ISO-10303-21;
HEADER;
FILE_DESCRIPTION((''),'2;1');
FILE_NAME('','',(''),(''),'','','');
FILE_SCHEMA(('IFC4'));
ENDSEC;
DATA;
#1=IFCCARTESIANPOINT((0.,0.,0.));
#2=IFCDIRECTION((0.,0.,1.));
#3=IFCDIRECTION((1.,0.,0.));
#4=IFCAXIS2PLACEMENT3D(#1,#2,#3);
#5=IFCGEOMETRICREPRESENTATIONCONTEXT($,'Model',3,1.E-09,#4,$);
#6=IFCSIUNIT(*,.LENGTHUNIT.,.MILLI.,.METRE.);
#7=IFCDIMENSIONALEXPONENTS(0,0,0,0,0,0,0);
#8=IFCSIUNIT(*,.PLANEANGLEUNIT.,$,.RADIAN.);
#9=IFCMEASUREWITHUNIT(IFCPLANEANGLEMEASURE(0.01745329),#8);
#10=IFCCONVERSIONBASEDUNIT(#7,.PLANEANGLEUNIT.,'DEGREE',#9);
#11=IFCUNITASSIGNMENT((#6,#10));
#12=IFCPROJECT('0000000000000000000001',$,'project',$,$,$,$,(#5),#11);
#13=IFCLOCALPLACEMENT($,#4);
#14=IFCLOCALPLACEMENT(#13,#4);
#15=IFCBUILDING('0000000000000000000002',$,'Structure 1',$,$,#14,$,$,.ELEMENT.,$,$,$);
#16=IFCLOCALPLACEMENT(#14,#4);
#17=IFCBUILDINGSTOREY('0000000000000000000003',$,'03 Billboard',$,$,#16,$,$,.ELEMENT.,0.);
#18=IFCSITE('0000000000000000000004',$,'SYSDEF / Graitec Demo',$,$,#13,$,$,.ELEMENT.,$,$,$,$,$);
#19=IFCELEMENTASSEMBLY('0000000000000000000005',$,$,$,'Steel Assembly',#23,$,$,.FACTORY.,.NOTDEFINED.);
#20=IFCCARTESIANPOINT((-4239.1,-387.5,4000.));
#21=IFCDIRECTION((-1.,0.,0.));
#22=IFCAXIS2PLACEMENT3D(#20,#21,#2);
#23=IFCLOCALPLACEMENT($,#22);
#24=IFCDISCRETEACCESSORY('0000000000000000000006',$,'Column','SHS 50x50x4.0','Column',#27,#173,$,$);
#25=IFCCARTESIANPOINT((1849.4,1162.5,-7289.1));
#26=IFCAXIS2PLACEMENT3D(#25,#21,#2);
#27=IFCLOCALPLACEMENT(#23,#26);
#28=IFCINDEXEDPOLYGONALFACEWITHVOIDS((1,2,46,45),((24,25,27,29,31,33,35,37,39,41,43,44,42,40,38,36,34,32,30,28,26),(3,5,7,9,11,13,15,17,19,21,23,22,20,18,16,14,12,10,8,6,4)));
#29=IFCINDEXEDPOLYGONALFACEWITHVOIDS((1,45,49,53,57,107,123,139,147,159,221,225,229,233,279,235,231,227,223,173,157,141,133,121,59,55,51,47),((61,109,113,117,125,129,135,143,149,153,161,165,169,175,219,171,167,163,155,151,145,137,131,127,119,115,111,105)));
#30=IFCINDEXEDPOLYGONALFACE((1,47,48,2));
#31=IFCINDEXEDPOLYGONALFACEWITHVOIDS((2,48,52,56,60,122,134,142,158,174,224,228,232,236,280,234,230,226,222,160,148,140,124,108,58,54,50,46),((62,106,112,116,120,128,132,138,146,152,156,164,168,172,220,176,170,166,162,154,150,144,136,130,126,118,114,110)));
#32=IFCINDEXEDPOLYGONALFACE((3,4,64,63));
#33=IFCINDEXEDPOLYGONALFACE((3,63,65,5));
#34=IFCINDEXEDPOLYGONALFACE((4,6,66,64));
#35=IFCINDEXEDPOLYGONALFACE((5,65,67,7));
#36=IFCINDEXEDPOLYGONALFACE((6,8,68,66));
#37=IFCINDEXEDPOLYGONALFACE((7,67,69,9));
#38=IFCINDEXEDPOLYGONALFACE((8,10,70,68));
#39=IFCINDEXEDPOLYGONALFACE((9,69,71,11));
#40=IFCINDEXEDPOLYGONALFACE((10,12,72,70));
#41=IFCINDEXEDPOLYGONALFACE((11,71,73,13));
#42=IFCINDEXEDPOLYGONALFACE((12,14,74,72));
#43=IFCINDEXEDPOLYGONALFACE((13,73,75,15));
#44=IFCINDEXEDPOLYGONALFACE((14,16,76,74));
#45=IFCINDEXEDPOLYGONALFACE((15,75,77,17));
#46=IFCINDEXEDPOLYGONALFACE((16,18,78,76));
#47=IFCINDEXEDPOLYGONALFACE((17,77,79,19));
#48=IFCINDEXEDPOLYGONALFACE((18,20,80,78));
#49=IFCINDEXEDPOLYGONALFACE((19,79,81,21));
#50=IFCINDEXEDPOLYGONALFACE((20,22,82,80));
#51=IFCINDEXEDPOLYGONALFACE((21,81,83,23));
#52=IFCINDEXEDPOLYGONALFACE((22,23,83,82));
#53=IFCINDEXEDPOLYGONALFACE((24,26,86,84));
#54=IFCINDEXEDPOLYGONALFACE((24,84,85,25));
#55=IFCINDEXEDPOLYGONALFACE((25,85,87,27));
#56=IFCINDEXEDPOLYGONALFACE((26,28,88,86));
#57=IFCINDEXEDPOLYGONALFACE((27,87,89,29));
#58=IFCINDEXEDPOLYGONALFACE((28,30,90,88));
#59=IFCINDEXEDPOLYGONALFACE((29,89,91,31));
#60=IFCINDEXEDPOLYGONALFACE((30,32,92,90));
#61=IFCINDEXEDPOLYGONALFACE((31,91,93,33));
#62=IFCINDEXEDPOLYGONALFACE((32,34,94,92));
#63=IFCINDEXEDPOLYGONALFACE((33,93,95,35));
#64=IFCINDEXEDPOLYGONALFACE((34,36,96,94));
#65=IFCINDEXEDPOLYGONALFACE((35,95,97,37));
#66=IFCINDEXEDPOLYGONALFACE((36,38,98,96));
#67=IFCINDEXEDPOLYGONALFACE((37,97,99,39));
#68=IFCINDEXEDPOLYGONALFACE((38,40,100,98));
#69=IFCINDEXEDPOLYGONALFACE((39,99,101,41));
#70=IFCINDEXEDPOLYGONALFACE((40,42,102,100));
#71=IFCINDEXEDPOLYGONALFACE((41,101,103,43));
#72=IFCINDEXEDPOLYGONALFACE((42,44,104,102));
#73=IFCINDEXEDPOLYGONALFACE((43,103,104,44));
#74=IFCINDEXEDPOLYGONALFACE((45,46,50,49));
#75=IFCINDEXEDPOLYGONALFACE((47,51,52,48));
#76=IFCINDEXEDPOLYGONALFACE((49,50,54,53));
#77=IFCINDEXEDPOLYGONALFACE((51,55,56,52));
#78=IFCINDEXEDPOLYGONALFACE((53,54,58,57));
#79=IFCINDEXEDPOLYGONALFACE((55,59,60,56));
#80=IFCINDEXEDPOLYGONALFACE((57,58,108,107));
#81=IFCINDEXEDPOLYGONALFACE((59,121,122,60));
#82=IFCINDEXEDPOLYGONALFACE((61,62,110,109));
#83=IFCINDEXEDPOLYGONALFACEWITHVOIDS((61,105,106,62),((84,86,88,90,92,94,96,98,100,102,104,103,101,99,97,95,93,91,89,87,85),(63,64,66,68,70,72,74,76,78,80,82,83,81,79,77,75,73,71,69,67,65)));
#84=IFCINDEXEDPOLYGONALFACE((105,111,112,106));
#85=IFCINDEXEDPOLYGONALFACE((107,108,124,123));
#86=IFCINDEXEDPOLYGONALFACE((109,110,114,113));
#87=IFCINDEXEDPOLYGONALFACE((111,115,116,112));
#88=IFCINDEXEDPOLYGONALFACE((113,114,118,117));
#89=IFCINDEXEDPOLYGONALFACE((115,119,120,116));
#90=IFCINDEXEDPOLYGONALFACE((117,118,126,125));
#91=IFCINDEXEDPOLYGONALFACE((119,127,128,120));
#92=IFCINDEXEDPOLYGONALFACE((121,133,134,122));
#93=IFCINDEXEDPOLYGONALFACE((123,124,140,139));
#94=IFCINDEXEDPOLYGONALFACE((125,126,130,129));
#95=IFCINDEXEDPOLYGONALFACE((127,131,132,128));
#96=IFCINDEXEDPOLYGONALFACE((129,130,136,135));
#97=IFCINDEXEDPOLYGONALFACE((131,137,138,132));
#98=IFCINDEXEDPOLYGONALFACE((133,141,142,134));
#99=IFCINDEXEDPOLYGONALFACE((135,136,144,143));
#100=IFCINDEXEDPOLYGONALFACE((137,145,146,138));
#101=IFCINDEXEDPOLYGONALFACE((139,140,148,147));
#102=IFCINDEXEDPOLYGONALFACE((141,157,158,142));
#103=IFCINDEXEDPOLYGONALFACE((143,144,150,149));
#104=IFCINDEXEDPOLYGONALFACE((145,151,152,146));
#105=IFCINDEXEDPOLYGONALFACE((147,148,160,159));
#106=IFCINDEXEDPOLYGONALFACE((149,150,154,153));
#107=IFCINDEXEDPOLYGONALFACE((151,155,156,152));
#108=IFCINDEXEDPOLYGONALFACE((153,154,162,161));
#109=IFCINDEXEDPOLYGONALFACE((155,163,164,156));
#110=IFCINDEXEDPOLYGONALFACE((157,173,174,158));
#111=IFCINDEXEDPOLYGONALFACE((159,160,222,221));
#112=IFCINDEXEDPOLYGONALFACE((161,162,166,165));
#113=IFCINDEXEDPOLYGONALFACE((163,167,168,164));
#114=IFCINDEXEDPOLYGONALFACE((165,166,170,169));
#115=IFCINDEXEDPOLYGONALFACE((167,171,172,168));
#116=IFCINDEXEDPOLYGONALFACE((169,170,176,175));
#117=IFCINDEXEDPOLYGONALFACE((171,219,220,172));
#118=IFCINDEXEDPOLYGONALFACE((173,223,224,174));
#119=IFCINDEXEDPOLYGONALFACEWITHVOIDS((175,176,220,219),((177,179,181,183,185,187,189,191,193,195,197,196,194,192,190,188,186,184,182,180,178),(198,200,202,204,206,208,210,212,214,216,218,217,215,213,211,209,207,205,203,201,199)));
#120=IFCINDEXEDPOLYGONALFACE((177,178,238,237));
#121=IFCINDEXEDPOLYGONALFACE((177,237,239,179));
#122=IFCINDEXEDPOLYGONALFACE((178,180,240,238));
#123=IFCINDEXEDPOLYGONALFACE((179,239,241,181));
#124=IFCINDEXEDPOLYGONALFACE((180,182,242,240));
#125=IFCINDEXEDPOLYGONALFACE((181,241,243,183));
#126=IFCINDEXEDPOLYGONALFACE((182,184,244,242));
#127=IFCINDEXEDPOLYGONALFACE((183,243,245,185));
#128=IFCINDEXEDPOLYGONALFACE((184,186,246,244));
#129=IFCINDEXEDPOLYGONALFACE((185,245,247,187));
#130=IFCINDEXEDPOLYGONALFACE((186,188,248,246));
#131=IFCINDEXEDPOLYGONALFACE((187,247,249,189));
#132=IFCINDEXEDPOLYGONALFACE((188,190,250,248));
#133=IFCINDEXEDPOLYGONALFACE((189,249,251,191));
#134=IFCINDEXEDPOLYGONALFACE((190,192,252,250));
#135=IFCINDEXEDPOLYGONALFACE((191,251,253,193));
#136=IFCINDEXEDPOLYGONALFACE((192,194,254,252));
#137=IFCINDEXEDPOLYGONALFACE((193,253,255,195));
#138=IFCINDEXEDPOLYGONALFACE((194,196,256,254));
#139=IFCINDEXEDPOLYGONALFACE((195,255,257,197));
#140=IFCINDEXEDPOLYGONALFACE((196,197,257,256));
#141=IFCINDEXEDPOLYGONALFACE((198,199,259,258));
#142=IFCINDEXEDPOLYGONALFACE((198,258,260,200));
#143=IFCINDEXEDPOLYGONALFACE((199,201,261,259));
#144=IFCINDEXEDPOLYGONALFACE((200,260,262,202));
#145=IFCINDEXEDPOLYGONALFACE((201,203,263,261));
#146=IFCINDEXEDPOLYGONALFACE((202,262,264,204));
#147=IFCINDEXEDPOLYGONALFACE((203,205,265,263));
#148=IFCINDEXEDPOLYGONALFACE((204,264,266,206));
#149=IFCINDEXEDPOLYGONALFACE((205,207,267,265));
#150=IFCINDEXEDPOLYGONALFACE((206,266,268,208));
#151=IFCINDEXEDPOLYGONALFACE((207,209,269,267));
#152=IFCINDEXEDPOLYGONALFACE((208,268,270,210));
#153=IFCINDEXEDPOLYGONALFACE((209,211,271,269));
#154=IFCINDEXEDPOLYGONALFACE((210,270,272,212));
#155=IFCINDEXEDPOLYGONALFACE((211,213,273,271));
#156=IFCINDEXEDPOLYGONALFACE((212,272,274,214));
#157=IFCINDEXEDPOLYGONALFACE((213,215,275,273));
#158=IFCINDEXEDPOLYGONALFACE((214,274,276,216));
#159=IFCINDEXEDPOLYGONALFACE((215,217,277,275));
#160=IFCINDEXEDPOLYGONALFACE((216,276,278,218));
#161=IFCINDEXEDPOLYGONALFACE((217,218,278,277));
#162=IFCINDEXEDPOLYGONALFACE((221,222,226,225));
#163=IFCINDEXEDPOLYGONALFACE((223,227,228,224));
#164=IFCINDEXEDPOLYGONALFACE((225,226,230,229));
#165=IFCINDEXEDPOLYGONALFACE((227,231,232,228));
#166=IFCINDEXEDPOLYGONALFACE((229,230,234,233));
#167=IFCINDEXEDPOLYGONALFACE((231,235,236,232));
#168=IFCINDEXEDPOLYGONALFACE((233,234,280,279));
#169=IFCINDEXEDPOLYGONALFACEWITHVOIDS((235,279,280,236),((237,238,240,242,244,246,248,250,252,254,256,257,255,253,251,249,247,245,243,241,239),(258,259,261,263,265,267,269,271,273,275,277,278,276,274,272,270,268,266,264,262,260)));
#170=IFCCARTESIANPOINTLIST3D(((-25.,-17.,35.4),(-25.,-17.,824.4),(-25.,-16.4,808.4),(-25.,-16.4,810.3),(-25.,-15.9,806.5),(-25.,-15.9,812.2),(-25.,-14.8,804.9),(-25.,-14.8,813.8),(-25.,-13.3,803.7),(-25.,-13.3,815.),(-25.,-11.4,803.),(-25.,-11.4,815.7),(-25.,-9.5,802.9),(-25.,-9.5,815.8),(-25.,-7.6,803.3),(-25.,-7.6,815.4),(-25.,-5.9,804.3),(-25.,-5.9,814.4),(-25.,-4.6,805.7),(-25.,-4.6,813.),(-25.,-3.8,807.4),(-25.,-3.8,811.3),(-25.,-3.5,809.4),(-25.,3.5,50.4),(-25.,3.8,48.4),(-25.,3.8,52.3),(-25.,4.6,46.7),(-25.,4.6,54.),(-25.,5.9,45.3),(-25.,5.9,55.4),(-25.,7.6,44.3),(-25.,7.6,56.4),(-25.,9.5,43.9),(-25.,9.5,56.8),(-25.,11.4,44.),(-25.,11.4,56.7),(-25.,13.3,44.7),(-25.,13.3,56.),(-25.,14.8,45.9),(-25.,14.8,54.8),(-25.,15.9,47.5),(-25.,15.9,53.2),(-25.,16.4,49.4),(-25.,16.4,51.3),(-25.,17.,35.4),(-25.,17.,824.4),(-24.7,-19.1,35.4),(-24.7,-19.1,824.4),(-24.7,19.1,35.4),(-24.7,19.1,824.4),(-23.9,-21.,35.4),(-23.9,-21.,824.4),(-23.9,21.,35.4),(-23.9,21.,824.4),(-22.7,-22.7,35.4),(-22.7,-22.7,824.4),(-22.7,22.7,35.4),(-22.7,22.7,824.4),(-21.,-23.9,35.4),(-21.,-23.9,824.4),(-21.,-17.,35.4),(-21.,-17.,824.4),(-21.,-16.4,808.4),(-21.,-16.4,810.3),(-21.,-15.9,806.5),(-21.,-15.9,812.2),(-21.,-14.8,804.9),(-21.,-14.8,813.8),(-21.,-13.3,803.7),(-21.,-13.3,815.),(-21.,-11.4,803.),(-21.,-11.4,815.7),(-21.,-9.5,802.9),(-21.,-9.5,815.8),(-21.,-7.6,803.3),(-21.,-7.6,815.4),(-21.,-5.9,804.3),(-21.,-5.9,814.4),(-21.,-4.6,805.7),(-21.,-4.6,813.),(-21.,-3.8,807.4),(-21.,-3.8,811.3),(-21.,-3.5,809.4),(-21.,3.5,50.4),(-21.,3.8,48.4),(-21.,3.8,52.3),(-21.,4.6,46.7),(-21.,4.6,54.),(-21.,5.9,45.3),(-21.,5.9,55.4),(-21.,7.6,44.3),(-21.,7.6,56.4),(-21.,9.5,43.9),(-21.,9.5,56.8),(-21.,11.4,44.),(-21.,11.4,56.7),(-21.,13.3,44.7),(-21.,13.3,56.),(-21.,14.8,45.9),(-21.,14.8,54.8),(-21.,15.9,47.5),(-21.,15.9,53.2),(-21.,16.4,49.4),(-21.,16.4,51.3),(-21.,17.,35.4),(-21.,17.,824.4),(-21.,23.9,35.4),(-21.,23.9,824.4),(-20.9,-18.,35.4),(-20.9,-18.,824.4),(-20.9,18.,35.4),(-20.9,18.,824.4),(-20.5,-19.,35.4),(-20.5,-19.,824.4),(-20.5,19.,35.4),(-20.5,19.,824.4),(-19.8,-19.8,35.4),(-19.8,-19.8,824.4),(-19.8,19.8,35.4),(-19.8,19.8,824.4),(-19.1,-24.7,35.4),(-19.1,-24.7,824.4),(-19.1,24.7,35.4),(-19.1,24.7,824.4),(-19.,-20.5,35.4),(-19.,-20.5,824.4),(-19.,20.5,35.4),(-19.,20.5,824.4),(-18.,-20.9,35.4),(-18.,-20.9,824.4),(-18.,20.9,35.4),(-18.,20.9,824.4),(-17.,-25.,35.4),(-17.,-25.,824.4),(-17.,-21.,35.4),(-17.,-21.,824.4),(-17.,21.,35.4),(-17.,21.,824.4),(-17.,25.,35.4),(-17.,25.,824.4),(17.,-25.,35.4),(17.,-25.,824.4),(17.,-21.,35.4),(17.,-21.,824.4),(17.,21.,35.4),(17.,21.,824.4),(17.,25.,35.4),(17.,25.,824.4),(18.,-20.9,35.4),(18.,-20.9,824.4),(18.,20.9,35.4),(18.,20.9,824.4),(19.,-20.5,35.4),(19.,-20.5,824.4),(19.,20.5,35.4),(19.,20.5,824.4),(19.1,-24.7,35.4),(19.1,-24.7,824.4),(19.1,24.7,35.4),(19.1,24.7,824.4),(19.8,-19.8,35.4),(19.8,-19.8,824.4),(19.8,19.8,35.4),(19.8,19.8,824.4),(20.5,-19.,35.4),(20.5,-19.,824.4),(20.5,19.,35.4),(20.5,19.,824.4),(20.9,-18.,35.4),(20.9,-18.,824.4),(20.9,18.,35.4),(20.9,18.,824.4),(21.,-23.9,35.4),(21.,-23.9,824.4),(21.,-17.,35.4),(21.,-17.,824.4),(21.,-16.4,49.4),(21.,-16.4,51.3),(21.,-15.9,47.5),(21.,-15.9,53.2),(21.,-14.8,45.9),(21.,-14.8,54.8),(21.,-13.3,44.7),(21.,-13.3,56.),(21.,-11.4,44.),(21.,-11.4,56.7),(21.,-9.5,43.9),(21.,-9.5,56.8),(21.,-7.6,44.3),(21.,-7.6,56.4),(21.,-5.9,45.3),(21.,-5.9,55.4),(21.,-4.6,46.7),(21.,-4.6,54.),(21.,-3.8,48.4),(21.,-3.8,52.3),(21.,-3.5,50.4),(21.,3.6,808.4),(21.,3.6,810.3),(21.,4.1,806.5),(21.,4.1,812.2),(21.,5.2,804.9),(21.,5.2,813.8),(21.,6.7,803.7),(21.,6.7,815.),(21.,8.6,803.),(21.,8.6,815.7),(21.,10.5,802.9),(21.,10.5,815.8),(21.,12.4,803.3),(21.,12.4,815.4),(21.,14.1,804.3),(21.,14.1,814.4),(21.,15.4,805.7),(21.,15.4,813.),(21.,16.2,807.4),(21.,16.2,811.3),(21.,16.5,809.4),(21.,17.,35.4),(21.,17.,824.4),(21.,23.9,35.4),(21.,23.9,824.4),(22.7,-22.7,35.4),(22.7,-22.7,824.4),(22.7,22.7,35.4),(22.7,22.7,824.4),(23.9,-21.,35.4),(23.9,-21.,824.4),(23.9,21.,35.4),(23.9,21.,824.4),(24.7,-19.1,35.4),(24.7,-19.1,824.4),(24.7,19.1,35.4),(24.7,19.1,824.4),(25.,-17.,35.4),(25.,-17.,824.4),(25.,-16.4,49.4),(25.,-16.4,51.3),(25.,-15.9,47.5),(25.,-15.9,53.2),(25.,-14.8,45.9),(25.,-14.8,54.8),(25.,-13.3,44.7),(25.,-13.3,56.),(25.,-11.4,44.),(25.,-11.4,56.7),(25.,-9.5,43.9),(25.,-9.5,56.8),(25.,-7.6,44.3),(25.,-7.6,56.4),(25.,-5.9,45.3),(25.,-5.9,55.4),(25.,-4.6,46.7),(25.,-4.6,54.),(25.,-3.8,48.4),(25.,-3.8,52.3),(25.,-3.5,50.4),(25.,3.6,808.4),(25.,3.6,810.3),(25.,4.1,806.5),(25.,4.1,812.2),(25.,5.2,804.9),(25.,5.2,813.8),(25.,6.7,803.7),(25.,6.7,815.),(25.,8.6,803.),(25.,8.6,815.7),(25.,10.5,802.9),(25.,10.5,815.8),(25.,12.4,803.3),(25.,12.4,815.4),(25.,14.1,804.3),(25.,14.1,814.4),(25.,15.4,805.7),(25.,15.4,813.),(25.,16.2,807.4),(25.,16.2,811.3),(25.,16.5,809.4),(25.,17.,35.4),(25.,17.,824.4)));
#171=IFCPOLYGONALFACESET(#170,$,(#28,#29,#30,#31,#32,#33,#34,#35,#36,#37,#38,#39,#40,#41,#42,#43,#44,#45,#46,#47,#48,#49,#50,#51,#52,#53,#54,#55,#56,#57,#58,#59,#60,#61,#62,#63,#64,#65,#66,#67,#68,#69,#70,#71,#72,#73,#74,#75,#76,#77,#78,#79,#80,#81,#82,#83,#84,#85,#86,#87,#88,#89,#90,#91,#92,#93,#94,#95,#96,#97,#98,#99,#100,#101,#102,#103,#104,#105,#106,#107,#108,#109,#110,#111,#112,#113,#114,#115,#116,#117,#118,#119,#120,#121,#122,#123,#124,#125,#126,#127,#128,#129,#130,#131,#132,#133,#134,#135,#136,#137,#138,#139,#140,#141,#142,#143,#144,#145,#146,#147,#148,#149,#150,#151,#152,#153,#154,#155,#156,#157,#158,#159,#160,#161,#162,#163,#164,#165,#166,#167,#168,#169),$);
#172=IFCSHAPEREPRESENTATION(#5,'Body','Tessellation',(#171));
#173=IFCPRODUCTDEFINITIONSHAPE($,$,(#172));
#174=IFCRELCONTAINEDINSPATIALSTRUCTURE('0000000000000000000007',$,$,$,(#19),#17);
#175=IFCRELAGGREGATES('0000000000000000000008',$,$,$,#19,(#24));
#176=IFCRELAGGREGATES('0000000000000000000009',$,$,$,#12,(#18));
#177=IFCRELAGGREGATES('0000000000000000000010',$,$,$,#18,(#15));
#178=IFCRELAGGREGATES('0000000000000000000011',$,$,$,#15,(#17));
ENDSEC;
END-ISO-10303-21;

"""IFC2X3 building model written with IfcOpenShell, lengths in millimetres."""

from ifc_helpers import new_model, entity, si_unit, converted_unit, frame, frame_2d, origin, origin_with_axes, origin_2d, origin_2d_with_axis, place, context, project, spatial, hollow_rectangle, circle, extrude, clip, halfspace, element, aggregate, save


model = new_model("IFC2X3")

# Units and contexts
model_context = context("Model", 3, precision=1e-09, world=origin_with_axes())
ifc_project = project(units=[si_unit("LENGTHUNIT", "METRE", prefix="MILLI"), converted_unit("PLANEANGLEUNIT", "DEGREE", entity("IfcPlaneAngleMeasure", 0.01745329), si_unit("PLANEANGLEUNIT", "RADIAN"), dimensions=[0, 0, 0, 0, 0, 0, 0])], contexts=[model_context])

# Site, building, storey
site_placement = place(None, origin_with_axes())
site = spatial("IfcSite", under=ifc_project, at=site_placement, Name="SYSDEF / Graitec Demo", CompositionType="ELEMENT")
building_placement = place(site_placement, origin_with_axes())
building = spatial("IfcBuilding", under=site, at=building_placement, Name="Structure 1", CompositionType="ELEMENT")
storey_placement = place(building_placement, origin_with_axes())
storey = spatial("IfcBuildingStorey", under=building, at=storey_placement, Name="03 Billboard", CompositionType="ELEMENT", Elevation=0.0)

# Element assembly, discrete accessory, openings
assembly_1_placement = place(None, frame((-4239.1, -387.5, 4000.0), z_axis=(-1.0, 0.0, 0.0), x_axis=(0.0, 0.0, 1.0)))
assembly_1 = element("IfcElementAssembly", 1, at=assembly_1_placement, inside=storey, ObjectType="Steel Assembly", AssemblyPlace="FACTORY", PredefinedType="NOTDEFINED")
discrete_accessory_1_placement = place(assembly_1_placement, frame((1849.4, 1162.5, -7289.1), z_axis=(-1.0, 0.0, 0.0), x_axis=(0.0, 0.0, 1.0)))
discrete_accessory_1 = element("IfcDiscreteAccessory", 2, at=discrete_accessory_1_placement, Name="Column", Description="SHS 50x50x4.0", ObjectType="Column", context=model_context, shape_type="Clipping", body=[
    clip(clip(extrude(hollow_rectangle(XDim=50.0, YDim=50.0, WallThickness=4.0, InnerFilletRadius=4.0, OuterFilletRadius=8.0, at=origin_2d()), origin(), (0.0, 0.0, 1.0), 859.7), halfspace(frame((3050.0, -775.0, 824.4), z_axis=(0.0, 0.0, -1.0), x_axis=(-1.0, 0.0, 0.0)), True)), halfspace(frame((3050.0, -775.0, 35.4), z_axis=(0.0, 0.0, 1.0), x_axis=(1.0, 0.0, 0.0)), True)),
])
opening_1_placement = place(discrete_accessory_1_placement, frame((-20.5, -10.0, 809.4), z_axis=(-1.0, 0.0, 0.0), x_axis=(0.0, 1.0, 0.0)))
element("IfcOpeningElement", 3, at=opening_1_placement, cuts=discrete_accessory_1, ObjectType="Opening", context=model_context, shape_type="SweptSolid", body=[
    extrude(circle(Radius=6.5, at=origin_2d_with_axis()), origin(), (0.0, 0.0, 1.0), 5.0),
])
opening_2_placement = place(discrete_accessory_1_placement, frame((25.5, 16.5, 809.4), z_axis=(1.0, 0.0, 0.0), x_axis=(0.0, 1.0, 0.0)))
element("IfcOpeningElement", 4, at=opening_2_placement, cuts=discrete_accessory_1, ObjectType="Opening", context=model_context, shape_type="SweptSolid", body=[
    extrude(circle(Radius=6.5, at=frame_2d((-6.5, 0.0), x_axis=(1.0, 0.0))), origin(), (0.0, 0.0, -1.0), 5.0),
])
opening_3_placement = place(discrete_accessory_1_placement, frame((-20.5, 10.0, 50.4), z_axis=(-1.0, 0.0, 0.0), x_axis=(0.0, -1.0, 0.0)))
element("IfcOpeningElement", 5, at=opening_3_placement, cuts=discrete_accessory_1, ObjectType="Opening", context=model_context, shape_type="SweptSolid", body=[
    extrude(circle(Radius=6.5, at=origin_2d_with_axis()), origin(), (0.0, 0.0, 1.0), 5.0),
])
opening_4_placement = place(discrete_accessory_1_placement, frame((25.5, -16.5, 50.4), z_axis=(1.0, 0.0, 0.0), x_axis=(0.0, 1.0, 0.0)))
element("IfcOpeningElement", 6, at=opening_4_placement, cuts=discrete_accessory_1, ObjectType="Opening", context=model_context, shape_type="SweptSolid", body=[
    extrude(circle(Radius=6.5, at=frame_2d((6.5, 0.0), x_axis=(1.0, 0.0))), origin(), (0.0, 0.0, -1.0), 5.0),
])
aggregate(assembly_1, [discrete_accessory_1])

save(model, "model.ifc")
